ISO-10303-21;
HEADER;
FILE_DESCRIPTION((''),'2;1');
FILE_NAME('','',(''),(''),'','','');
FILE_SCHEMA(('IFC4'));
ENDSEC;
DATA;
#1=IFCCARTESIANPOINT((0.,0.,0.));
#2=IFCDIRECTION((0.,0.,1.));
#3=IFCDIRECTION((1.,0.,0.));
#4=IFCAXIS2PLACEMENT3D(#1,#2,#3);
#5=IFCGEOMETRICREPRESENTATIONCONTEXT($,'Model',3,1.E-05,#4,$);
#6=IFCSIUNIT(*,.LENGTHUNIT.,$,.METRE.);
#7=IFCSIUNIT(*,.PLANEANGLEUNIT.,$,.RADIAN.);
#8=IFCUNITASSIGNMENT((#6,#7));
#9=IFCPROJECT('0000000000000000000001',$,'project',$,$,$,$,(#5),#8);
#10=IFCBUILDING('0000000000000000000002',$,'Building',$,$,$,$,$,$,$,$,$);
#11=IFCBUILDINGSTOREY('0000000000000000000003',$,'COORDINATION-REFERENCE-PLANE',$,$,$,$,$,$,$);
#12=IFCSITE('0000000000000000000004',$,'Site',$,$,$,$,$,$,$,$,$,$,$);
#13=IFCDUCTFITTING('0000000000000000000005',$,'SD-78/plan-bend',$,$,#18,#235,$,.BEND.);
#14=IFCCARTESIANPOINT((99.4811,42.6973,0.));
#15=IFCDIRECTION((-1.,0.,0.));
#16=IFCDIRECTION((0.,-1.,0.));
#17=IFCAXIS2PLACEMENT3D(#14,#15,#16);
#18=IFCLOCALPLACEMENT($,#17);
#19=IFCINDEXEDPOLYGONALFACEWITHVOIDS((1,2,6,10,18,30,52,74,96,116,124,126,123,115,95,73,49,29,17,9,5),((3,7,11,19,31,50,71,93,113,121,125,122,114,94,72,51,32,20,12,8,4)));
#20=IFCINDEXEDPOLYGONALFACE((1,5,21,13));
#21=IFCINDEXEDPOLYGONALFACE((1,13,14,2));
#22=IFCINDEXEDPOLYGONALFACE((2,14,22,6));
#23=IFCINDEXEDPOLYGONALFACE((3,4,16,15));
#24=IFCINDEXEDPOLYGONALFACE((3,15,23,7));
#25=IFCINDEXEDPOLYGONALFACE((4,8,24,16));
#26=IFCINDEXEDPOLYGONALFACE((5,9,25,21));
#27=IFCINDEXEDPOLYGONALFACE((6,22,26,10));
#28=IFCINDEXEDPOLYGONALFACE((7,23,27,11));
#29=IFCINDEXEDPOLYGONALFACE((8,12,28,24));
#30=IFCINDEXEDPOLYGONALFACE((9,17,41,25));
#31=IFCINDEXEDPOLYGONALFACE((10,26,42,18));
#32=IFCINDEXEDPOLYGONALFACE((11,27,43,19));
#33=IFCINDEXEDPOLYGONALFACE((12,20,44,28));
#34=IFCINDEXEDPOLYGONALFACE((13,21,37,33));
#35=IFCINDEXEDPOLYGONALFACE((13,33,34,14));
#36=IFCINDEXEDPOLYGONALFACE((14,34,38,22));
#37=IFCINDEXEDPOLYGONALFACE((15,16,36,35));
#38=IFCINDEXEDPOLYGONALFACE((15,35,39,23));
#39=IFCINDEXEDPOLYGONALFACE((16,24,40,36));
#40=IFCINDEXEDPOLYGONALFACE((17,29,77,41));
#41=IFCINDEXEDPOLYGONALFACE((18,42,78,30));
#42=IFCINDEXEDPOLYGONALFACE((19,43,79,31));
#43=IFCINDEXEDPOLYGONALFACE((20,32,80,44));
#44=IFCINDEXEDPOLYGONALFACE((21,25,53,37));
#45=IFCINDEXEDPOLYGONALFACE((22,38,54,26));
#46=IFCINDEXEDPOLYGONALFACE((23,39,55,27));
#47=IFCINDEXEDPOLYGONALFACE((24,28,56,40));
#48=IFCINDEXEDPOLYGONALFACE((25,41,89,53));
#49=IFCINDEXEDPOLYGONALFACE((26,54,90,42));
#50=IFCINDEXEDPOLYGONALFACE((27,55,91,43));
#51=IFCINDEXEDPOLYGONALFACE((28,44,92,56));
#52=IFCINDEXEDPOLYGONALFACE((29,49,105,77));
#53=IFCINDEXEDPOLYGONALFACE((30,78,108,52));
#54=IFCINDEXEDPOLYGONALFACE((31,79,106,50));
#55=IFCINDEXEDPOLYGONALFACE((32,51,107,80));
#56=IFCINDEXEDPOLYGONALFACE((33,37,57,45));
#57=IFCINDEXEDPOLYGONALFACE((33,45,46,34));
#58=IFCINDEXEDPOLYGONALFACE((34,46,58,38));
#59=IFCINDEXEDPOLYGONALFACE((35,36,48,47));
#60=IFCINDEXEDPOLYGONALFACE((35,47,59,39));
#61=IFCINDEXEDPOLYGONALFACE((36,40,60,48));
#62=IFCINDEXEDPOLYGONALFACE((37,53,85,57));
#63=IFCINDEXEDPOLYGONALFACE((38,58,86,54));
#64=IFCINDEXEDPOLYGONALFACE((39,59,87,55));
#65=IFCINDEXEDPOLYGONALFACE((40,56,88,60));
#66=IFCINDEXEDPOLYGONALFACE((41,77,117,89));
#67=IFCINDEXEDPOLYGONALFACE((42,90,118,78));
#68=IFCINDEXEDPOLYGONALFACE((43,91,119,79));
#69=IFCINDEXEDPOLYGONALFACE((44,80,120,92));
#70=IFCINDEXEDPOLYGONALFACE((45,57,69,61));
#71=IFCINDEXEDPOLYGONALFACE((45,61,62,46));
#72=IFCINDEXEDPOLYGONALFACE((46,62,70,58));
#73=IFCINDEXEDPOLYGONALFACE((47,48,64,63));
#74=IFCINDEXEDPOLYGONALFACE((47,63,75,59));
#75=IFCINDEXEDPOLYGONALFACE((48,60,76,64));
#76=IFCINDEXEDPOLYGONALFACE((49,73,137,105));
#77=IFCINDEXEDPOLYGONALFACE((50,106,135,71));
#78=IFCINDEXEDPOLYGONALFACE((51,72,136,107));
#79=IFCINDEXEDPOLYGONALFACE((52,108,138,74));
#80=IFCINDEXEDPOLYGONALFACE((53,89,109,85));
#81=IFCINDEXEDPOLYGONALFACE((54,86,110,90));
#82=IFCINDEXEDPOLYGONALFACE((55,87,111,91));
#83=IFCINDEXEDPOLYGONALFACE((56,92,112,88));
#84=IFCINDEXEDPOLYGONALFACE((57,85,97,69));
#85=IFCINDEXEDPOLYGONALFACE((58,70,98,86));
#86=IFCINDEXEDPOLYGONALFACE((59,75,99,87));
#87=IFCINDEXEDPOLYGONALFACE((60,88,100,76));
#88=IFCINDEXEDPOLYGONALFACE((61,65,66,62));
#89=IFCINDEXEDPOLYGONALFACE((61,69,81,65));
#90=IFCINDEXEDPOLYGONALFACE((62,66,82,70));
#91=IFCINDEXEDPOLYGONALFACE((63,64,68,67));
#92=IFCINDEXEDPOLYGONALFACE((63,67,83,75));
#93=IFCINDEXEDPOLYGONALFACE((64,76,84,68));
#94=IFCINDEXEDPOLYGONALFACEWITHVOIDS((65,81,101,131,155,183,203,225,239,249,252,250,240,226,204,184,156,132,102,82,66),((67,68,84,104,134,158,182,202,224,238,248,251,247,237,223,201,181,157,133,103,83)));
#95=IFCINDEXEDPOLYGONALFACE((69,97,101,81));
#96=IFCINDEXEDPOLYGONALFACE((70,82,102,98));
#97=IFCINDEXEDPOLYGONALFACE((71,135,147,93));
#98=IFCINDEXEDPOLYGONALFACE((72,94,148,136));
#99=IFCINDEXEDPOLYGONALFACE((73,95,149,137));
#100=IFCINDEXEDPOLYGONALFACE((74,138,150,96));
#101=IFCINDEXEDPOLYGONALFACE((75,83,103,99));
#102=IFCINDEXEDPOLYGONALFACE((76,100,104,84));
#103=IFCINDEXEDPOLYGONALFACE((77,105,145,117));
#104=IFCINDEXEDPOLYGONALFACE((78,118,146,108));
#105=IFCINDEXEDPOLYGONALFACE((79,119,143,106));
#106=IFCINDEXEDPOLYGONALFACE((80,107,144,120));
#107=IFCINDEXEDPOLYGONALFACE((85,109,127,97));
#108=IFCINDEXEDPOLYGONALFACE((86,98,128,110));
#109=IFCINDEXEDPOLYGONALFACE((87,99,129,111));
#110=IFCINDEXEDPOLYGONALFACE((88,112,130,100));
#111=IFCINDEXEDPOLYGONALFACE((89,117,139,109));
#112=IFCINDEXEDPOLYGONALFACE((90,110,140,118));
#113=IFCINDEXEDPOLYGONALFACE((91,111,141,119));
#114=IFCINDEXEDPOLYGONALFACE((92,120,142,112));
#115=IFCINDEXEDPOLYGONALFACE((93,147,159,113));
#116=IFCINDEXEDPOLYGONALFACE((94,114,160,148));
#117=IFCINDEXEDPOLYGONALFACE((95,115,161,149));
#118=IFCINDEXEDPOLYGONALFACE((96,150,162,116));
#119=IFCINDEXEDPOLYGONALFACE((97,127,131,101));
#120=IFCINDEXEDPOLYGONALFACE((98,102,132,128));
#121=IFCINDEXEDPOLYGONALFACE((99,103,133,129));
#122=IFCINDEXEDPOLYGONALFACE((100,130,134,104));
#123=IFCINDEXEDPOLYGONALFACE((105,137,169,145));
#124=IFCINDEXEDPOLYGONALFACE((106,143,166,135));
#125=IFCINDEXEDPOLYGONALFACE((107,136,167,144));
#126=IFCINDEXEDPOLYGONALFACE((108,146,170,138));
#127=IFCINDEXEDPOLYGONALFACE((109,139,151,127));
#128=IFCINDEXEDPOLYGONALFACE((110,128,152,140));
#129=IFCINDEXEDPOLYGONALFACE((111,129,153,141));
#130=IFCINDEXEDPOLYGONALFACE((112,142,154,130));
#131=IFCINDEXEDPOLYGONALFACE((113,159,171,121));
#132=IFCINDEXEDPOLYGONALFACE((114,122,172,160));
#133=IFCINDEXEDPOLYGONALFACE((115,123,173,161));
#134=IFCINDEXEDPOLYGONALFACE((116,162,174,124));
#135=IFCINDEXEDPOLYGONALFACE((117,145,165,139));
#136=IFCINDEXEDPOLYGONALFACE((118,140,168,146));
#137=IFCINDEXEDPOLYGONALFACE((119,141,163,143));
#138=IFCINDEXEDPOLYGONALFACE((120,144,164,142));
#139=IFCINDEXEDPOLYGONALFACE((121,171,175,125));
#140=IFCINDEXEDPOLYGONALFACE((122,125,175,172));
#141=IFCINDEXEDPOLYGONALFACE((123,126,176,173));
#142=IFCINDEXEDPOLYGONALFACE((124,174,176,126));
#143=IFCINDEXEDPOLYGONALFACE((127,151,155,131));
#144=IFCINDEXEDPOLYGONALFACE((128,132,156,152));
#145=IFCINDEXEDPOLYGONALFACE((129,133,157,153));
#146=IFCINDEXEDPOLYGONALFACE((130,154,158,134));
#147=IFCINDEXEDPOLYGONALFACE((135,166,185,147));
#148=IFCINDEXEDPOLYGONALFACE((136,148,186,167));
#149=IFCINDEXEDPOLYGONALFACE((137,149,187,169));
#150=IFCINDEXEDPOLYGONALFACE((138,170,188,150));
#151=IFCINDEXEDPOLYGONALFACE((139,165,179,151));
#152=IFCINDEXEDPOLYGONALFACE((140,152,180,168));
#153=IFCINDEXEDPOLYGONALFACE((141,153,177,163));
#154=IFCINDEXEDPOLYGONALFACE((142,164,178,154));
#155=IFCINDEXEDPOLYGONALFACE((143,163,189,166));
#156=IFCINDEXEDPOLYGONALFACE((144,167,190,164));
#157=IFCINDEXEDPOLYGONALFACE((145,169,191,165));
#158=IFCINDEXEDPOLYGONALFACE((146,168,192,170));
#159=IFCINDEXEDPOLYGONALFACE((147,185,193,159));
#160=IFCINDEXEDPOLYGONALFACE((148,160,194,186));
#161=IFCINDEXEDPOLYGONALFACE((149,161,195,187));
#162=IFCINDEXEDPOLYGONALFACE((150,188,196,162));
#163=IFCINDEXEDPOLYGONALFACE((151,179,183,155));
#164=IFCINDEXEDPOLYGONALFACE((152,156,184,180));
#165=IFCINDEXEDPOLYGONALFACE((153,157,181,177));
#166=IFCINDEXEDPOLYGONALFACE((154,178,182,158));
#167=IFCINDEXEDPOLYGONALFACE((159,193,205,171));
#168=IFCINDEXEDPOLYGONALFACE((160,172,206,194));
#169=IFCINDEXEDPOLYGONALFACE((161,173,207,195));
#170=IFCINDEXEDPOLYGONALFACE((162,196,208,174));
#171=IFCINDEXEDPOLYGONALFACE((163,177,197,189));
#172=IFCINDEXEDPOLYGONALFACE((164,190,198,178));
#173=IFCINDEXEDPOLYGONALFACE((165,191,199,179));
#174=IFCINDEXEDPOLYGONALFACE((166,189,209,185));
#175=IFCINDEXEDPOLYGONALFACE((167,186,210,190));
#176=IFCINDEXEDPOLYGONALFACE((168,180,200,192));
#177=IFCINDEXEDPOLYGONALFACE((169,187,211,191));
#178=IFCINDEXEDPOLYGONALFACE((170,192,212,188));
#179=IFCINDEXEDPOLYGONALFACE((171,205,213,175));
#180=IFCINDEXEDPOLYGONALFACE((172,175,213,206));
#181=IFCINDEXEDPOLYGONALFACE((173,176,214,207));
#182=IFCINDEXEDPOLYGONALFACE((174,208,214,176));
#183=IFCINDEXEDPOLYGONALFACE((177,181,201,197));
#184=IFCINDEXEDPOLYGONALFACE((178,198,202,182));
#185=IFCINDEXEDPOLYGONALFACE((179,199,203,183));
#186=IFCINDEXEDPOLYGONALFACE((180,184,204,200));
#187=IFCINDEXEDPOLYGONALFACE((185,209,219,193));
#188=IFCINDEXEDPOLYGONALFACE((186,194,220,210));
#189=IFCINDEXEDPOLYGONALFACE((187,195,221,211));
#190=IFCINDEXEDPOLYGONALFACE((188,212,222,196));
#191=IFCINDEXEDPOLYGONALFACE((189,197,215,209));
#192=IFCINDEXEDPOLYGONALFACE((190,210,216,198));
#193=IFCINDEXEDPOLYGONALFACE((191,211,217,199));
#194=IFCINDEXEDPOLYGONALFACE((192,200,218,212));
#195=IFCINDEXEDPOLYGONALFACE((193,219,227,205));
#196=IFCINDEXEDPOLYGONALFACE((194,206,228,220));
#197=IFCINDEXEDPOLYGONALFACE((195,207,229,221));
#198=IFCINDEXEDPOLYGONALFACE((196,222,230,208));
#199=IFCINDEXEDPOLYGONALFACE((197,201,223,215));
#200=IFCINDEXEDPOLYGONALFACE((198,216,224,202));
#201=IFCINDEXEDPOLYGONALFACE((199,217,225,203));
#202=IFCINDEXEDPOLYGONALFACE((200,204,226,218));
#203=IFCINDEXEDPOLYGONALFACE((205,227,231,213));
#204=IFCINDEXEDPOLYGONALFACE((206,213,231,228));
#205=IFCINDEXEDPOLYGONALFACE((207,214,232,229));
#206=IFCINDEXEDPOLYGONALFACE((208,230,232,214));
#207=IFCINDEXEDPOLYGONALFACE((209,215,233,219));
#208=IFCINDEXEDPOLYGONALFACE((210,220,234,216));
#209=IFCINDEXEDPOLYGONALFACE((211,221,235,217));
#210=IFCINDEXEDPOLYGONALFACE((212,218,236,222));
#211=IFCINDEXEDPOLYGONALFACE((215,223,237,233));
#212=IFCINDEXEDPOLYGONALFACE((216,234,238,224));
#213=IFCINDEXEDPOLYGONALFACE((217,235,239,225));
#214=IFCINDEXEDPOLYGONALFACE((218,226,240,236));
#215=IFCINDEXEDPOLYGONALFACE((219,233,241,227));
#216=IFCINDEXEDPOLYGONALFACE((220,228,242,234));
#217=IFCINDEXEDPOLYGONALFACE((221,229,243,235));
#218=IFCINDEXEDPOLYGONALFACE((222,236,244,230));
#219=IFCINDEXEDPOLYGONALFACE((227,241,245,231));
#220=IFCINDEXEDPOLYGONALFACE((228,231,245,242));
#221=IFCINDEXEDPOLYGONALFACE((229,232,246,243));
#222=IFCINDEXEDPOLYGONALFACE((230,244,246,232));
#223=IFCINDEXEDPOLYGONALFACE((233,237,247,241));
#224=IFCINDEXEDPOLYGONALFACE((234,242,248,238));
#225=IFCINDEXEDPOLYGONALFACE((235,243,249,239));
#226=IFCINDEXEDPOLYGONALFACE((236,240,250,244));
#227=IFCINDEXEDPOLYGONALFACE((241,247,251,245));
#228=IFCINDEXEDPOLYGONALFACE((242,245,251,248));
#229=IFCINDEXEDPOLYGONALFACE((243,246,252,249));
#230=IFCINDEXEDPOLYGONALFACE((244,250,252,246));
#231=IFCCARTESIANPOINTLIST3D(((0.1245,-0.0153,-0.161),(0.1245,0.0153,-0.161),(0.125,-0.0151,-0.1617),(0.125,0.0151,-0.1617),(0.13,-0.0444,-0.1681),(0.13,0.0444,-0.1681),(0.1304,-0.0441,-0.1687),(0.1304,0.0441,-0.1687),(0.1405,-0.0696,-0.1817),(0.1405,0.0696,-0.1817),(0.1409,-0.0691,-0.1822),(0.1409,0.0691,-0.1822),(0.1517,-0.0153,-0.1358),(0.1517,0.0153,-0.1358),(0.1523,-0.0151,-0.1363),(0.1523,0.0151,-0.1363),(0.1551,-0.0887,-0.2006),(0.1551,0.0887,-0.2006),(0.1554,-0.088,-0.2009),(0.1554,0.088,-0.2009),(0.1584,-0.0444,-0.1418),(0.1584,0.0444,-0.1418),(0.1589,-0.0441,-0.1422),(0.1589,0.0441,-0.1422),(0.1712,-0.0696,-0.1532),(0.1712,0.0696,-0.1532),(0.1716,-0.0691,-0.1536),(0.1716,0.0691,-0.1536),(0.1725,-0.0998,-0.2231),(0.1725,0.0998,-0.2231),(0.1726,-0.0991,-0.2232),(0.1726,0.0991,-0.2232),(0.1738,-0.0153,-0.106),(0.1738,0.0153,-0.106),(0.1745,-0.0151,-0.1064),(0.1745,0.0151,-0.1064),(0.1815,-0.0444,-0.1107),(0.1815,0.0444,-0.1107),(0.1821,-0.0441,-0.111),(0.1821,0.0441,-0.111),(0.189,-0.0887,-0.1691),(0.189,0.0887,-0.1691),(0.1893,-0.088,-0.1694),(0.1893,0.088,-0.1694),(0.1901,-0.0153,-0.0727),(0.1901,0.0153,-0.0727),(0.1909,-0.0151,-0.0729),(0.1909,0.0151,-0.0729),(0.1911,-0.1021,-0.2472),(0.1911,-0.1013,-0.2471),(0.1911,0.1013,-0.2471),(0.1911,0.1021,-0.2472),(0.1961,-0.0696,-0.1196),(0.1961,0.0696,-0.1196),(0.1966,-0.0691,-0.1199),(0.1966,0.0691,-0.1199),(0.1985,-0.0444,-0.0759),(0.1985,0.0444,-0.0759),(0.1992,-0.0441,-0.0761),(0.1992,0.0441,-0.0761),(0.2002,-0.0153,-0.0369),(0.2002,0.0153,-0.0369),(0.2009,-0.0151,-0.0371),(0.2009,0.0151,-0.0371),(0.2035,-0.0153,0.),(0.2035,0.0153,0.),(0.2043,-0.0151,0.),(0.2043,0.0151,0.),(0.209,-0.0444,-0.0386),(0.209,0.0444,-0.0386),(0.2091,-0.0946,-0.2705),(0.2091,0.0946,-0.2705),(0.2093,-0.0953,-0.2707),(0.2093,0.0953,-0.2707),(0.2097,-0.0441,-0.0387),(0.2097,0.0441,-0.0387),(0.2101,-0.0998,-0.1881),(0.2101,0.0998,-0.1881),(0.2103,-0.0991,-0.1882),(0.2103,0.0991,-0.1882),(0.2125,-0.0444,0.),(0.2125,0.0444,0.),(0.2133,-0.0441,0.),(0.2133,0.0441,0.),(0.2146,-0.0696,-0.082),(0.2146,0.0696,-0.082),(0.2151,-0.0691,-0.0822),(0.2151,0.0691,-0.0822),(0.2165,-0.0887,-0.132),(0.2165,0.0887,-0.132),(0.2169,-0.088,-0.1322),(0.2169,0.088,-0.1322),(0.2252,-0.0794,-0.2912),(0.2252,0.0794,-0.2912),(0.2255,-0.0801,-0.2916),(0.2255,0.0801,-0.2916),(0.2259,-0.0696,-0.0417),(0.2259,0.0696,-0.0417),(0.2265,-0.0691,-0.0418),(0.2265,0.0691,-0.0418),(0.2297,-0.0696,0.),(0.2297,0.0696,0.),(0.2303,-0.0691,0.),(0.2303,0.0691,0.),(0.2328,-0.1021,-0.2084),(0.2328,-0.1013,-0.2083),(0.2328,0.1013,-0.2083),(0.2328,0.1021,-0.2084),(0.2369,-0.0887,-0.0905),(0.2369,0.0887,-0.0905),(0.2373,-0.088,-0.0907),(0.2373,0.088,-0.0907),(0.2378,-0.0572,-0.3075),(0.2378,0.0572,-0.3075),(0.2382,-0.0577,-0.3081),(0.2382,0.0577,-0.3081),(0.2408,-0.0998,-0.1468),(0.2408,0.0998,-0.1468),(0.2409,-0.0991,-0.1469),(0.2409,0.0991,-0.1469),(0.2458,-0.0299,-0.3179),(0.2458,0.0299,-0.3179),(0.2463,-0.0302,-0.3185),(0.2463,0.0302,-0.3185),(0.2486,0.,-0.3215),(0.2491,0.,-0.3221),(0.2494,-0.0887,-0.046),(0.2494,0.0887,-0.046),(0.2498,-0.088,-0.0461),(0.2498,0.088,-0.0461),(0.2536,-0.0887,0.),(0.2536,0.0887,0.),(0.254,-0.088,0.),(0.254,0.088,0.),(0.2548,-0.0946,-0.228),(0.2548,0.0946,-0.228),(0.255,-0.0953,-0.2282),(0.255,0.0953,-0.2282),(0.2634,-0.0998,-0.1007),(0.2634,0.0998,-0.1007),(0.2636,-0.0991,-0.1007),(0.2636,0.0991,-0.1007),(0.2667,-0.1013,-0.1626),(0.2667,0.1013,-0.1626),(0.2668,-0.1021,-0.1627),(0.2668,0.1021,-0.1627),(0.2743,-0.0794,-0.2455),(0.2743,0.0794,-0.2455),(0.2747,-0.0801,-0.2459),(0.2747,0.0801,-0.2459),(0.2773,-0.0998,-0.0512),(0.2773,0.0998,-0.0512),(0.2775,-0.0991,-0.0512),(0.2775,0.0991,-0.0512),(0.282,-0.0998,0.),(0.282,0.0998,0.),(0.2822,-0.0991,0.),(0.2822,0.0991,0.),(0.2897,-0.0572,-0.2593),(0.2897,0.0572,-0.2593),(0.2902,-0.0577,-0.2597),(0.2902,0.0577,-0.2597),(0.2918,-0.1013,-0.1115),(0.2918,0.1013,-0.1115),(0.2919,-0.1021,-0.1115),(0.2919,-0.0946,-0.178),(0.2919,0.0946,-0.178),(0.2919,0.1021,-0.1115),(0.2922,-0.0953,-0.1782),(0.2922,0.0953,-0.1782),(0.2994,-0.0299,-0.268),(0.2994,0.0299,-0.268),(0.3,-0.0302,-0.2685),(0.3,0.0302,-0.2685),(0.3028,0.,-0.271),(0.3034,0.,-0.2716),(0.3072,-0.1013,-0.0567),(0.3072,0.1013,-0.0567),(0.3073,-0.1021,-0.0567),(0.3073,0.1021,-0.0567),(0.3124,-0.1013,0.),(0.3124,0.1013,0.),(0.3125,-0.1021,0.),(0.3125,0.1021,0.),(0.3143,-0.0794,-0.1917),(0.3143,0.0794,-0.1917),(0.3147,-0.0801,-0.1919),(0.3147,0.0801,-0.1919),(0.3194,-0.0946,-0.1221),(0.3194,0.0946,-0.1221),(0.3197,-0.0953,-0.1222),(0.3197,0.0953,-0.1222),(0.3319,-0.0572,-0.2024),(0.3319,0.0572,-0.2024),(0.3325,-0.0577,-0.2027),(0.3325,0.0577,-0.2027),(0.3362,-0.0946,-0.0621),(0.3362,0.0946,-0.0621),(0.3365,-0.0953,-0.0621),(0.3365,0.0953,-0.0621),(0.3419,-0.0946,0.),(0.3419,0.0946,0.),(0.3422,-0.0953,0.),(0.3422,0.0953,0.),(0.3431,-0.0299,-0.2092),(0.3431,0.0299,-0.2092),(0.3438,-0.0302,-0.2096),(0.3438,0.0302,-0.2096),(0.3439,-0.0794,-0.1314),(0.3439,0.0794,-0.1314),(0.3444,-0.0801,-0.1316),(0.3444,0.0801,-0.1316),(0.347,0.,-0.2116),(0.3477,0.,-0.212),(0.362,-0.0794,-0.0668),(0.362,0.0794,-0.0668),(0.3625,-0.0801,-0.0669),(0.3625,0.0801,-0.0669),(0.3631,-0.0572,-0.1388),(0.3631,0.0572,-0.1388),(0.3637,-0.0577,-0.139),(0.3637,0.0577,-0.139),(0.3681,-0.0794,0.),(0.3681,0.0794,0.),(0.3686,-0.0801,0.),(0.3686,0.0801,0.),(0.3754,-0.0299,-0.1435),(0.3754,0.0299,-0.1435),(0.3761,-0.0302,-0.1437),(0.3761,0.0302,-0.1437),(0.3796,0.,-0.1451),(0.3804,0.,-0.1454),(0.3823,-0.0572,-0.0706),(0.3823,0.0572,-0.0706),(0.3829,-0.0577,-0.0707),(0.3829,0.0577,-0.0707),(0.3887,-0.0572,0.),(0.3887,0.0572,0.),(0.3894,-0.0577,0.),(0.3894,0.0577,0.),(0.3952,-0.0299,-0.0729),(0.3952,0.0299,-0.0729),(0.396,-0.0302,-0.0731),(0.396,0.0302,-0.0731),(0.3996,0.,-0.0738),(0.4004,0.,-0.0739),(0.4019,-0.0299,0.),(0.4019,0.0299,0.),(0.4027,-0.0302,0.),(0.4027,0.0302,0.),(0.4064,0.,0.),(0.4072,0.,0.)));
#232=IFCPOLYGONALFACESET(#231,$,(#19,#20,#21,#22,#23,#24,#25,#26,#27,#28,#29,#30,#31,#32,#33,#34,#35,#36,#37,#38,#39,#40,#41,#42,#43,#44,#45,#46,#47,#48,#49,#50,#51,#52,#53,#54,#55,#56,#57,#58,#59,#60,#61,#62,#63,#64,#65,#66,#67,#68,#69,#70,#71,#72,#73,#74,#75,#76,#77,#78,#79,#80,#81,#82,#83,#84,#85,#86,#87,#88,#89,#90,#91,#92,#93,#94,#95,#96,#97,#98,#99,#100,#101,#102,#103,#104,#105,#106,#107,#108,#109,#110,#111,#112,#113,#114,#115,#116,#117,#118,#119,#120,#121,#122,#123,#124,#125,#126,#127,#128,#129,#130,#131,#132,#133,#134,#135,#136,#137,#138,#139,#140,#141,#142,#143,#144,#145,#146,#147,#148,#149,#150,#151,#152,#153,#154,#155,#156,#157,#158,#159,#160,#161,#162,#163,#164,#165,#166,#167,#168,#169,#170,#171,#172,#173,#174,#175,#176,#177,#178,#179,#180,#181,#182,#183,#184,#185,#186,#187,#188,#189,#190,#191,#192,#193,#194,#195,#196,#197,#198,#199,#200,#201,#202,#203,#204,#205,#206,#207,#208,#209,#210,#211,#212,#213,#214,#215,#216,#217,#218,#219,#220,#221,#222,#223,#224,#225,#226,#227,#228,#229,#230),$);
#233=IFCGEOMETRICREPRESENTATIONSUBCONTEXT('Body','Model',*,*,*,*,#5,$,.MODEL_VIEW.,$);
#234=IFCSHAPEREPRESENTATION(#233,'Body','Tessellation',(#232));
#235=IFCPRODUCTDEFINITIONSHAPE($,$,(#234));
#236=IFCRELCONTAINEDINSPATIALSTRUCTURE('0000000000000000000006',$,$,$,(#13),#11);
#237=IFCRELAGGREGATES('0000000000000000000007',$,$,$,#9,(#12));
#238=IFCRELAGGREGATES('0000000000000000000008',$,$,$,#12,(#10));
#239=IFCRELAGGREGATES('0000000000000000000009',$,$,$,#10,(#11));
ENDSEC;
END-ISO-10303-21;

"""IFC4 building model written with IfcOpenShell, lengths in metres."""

from ifc_helpers import new_model, entity, si_unit, frame, origin_with_axes, place, context, subcontext, project, spatial, element, save


model = new_model("IFC4")

# Units and contexts
model_context = context("Model", 3, precision=1e-05, world=origin_with_axes())
body_context_1 = subcontext(model_context, "Body", "Model", "MODEL_VIEW")
ifc_project = project(units=[si_unit("LENGTHUNIT", "METRE"), si_unit("PLANEANGLEUNIT", "RADIAN")], contexts=[model_context])

# Site, building, storey
site = spatial("IfcSite", under=ifc_project, Name="Site")
building = spatial("IfcBuilding", under=site, Name="Building")
storey = spatial("IfcBuildingStorey", under=building, Name="COORDINATION-REFERENCE-PLANE")

# Duct fitting
duct_fitting_1_placement = place(None, frame((99.4811, 42.6973, 0.0), z_axis=(-1.0, 0.0, 0.0), x_axis=(0.0, -1.0, 0.0)))
element("IfcDuctFitting", 1, at=duct_fitting_1_placement, inside=storey, Name="SD-78/plan-bend", PredefinedType="BEND", context=body_context_1, shape_type="SweptSolid", body=[
    entity("IfcRevolvedAreaSolid", entity("IfcCircleHollowProfileDef", "AREA", None, entity("IfcAxis2Placement2D", entity("IfcCartesianPoint", [0.3048, 0.0])), 0.1024, 0.0008), entity("IfcAxis2Placement3D", entity("IfcCartesianPoint", [0.0, 0.0, 0.0]), entity("IfcDirection", [0.0, 0.0, 1.0]), entity("IfcDirection", [1.0, 0.0, 0.0])), entity("IfcAxis1Placement", entity("IfcCartesianPoint", [0.0, 0.0, 0.0]), entity("IfcDirection", [0.0, 1.0, 0.0])), 0.912619),
])

save(model, "model.ifc")
